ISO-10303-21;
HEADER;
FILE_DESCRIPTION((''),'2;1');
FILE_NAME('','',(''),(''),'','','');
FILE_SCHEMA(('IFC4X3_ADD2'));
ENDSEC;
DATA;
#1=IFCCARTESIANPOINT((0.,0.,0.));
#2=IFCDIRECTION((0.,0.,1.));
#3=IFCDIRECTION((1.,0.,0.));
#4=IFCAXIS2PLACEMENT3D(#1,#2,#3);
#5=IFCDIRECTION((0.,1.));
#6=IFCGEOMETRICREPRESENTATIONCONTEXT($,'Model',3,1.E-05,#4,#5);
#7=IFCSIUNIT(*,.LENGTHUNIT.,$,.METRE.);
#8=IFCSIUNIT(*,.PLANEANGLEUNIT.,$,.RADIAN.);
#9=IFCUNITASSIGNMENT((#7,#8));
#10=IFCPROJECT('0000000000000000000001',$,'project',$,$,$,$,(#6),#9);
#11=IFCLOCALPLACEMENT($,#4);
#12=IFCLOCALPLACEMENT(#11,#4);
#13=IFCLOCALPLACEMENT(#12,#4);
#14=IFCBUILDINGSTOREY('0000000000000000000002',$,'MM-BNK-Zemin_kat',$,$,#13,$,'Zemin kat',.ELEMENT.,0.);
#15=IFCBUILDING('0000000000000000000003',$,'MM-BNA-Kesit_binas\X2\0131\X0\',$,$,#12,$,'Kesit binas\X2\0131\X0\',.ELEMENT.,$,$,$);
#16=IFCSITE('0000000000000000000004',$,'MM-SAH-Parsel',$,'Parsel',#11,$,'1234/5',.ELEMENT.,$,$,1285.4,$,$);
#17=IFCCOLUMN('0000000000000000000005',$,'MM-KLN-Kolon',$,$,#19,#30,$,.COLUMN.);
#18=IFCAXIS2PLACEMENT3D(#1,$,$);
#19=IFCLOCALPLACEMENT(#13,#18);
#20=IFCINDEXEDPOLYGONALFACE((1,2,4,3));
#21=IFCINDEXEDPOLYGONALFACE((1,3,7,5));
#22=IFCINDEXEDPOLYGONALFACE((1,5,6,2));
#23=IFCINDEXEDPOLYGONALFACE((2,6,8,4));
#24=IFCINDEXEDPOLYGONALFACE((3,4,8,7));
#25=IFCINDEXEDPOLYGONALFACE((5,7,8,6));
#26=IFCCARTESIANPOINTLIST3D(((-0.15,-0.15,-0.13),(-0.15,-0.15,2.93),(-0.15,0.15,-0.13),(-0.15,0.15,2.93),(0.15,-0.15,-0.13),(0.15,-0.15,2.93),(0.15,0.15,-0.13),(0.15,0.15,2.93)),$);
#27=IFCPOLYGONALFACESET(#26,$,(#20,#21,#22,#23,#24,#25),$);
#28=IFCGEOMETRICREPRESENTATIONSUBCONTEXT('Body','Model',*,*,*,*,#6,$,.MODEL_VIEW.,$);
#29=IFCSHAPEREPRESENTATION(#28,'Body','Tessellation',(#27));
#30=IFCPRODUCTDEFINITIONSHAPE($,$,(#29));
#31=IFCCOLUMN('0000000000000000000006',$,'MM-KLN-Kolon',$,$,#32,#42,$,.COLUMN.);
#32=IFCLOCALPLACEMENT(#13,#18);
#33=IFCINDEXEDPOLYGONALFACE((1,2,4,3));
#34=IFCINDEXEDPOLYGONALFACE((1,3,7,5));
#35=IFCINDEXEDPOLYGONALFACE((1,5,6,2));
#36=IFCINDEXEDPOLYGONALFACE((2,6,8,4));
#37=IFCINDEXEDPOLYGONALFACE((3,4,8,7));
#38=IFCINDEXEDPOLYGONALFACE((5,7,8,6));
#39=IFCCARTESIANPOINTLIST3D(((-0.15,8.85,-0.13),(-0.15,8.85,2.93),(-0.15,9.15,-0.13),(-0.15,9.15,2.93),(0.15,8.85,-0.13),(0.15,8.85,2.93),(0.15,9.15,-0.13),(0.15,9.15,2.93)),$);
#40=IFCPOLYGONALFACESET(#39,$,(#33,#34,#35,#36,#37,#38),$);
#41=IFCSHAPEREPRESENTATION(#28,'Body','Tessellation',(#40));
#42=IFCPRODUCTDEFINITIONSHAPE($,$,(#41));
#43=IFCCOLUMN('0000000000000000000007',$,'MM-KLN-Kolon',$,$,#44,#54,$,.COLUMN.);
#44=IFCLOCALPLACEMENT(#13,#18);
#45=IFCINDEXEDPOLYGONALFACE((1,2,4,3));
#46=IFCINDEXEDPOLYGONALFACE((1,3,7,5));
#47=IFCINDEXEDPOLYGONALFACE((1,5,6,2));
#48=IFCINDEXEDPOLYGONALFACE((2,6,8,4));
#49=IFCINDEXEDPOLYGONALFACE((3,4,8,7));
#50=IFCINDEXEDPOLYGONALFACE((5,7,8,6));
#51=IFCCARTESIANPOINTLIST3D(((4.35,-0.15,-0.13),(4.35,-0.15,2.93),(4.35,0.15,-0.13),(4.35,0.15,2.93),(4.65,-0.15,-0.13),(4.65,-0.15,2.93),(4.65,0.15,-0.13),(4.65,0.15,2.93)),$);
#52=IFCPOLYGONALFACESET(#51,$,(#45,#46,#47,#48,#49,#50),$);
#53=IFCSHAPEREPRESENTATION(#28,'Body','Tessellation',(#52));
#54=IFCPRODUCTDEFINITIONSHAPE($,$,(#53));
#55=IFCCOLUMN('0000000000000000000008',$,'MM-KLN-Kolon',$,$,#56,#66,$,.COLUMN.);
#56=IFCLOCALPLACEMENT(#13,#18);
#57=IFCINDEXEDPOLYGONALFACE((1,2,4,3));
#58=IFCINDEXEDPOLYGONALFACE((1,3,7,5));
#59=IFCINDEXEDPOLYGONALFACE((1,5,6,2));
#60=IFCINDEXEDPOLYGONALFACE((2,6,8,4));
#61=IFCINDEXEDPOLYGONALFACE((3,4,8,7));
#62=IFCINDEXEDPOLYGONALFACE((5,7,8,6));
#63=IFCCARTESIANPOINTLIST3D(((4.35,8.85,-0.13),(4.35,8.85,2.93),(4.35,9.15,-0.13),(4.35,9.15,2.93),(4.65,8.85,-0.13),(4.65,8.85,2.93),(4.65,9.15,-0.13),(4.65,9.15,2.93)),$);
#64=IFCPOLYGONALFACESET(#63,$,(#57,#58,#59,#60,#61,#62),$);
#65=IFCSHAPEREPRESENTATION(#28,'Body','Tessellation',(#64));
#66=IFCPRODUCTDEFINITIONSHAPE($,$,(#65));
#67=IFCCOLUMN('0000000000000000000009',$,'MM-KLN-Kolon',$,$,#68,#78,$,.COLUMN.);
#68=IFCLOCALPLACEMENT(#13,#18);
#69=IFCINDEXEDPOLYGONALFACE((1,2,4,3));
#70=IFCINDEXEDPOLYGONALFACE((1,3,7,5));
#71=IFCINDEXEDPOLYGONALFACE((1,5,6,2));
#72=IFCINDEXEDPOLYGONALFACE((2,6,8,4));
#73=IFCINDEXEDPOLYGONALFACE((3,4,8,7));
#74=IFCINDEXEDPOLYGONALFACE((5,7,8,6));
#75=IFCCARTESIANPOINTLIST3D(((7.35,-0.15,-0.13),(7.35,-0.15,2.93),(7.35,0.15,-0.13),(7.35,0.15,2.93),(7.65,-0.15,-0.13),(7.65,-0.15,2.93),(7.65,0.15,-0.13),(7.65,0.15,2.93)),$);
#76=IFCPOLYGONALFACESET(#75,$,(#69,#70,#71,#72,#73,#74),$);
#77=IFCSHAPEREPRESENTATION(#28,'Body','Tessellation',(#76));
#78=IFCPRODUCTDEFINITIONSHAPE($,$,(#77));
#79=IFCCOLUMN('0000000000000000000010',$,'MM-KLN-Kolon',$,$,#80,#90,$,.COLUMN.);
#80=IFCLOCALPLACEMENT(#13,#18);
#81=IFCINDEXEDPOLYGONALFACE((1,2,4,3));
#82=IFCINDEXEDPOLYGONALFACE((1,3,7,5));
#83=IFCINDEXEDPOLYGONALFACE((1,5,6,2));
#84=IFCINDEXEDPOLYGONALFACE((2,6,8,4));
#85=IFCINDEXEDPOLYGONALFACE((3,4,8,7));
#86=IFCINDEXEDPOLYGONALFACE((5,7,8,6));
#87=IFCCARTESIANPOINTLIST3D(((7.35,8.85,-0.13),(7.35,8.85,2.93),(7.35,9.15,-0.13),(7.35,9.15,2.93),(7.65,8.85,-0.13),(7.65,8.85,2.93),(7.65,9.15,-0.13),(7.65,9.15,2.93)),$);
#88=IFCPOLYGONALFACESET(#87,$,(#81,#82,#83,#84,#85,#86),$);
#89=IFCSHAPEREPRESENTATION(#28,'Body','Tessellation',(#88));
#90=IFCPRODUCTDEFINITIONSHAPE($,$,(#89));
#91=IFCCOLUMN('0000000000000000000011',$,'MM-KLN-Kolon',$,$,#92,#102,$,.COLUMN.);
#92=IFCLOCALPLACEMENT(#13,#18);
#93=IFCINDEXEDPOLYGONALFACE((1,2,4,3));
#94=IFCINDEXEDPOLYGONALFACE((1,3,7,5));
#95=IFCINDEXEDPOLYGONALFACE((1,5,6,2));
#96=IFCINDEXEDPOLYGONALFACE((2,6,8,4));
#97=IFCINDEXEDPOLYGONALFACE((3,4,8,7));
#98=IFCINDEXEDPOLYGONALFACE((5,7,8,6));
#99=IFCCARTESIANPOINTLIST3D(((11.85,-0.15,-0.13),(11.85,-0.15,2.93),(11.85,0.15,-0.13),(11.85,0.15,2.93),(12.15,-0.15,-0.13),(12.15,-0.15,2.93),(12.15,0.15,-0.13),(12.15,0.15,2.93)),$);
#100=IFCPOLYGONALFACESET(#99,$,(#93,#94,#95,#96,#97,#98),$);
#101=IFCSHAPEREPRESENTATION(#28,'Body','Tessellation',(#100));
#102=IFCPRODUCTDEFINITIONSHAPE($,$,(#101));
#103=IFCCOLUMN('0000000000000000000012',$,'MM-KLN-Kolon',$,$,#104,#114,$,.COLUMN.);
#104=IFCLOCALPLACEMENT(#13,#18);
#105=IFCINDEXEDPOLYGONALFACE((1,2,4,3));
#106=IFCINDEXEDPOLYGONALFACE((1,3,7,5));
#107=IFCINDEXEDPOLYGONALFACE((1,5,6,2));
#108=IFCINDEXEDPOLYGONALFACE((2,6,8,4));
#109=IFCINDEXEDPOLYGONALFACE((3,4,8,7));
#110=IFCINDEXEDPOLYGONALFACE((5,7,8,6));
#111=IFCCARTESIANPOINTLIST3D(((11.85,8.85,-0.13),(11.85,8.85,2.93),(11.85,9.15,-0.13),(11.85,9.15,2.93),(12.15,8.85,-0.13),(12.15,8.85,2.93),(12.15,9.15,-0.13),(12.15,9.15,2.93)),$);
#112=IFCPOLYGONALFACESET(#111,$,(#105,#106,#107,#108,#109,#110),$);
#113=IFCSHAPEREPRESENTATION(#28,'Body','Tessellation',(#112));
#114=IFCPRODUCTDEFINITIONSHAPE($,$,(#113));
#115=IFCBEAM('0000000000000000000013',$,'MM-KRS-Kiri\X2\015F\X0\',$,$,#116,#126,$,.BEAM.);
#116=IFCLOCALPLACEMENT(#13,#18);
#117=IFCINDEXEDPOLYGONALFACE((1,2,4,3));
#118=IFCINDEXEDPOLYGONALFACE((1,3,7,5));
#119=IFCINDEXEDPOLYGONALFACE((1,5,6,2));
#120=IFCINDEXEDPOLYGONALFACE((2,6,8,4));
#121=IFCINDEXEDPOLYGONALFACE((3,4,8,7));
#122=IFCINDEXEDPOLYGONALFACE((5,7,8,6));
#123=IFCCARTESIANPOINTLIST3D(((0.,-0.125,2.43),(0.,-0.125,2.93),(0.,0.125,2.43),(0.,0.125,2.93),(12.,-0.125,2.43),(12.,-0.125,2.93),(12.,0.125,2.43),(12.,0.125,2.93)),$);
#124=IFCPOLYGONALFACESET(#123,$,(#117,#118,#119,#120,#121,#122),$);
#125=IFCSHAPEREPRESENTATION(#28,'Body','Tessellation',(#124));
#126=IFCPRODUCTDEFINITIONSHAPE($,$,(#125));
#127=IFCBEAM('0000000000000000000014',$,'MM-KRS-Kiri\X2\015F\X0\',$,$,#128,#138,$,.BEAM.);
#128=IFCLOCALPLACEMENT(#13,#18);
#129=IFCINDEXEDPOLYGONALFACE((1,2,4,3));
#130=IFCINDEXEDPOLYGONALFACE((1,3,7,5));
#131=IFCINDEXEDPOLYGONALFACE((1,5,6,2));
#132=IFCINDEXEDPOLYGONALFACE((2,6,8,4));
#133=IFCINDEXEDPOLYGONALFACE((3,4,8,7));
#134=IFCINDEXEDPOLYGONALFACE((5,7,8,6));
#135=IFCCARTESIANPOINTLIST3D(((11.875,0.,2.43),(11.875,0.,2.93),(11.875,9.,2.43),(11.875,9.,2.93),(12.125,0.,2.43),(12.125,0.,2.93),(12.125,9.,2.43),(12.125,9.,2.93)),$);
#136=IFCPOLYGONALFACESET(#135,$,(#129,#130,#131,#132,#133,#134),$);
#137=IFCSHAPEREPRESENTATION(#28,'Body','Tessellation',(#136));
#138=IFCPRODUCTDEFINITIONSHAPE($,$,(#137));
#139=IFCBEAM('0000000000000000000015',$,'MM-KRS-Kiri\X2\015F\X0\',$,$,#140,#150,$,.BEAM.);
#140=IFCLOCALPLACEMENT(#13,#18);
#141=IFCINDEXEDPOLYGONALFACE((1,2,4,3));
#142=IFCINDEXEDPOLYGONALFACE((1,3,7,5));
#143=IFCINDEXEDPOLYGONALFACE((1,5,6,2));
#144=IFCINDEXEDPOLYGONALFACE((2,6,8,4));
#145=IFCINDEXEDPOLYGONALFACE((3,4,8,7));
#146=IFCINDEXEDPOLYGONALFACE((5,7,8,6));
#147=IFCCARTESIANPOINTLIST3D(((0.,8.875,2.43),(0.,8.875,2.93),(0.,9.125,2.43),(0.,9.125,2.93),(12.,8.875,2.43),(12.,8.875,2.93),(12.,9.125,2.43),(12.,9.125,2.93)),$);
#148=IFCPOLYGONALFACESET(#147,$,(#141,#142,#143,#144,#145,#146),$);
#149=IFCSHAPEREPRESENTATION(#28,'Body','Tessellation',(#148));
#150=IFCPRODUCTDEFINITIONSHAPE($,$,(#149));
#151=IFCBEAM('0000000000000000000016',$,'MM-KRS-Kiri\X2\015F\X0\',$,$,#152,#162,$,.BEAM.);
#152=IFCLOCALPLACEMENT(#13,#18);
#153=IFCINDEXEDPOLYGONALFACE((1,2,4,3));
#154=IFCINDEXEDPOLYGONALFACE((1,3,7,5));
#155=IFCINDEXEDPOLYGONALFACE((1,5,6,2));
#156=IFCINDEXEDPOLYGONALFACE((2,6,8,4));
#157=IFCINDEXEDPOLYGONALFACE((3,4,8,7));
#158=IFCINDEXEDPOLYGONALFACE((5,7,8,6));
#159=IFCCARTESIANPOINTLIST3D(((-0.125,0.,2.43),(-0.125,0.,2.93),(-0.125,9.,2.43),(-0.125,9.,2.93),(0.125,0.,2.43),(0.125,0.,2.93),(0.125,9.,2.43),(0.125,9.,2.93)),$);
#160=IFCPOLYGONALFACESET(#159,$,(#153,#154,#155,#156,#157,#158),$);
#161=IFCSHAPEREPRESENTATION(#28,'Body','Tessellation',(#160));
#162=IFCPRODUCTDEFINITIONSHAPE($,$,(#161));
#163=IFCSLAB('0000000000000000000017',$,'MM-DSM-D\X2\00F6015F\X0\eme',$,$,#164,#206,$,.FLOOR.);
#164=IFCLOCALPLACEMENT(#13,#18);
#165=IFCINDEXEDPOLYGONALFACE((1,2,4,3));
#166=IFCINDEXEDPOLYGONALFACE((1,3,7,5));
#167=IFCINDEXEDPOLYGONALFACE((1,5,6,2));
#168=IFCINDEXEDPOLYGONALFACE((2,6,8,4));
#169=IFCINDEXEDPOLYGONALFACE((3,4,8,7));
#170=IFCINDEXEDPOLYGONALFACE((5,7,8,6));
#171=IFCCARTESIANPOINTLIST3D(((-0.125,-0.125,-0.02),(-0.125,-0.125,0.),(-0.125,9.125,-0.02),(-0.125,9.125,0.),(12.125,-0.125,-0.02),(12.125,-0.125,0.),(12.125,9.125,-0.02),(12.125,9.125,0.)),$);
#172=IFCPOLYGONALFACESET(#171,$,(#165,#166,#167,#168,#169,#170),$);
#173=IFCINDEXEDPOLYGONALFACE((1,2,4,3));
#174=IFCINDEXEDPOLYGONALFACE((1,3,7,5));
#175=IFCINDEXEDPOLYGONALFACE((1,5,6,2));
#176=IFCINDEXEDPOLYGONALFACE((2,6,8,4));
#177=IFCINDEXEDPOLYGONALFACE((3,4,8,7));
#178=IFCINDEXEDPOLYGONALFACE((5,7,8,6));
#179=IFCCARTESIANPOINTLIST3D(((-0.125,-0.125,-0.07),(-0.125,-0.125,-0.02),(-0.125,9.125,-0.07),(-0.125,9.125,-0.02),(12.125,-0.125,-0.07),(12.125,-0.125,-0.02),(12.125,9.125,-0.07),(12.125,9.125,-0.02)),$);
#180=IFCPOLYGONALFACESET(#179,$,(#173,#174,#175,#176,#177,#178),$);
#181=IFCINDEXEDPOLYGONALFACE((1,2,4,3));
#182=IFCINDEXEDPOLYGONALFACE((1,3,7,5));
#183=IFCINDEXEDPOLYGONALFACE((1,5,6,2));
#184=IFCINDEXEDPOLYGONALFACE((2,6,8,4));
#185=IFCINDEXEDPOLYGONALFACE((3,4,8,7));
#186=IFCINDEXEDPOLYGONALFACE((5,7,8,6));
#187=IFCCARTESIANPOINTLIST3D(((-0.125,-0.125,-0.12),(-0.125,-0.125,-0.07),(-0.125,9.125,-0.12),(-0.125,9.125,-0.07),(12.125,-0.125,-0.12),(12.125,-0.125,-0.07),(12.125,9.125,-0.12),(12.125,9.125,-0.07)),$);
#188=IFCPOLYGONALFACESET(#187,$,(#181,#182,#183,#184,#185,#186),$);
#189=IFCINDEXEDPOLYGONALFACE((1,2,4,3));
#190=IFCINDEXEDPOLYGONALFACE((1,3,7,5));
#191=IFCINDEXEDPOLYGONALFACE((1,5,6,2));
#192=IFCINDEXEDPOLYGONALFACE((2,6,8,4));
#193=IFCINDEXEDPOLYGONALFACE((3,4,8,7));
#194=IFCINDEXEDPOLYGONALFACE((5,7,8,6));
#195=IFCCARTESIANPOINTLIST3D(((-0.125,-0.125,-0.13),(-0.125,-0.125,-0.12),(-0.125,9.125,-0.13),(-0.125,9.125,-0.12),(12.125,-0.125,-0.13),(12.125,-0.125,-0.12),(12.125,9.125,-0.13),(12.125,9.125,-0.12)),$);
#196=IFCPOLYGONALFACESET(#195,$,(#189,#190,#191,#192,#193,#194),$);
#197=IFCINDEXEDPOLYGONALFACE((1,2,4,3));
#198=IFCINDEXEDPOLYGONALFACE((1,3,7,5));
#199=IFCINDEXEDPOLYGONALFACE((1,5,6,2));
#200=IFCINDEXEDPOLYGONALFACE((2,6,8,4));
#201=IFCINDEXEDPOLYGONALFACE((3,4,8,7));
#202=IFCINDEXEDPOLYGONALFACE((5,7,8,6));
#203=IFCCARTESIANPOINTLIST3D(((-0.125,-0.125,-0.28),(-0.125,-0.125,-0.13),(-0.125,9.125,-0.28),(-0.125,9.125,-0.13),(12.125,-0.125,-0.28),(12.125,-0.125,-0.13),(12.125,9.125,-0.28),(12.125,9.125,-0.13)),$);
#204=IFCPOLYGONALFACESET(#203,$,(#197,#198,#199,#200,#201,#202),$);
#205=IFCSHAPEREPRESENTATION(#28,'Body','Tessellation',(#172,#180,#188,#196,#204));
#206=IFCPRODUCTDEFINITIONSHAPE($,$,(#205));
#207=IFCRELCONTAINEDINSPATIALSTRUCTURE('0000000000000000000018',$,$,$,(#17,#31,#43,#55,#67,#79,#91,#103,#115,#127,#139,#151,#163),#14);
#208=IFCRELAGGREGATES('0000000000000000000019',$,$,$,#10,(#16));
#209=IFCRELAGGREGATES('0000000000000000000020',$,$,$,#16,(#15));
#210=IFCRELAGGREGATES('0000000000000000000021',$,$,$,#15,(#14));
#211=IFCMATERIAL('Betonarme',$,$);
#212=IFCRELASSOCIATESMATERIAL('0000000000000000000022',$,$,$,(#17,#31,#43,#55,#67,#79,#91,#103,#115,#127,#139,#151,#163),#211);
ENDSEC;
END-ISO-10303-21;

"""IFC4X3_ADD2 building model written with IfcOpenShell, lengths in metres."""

from ifc_helpers import new_model, si_unit, direction, frame, origin_with_axes, place, context, subcontext, project, spatial, polyline, outline, extrude, material, element, save


model = new_model("IFC4X3_ADD2")

# Units and contexts
model_context = context("Model", 3, precision=1e-05, world=origin_with_axes(), true_north=direction((0.0, 1.0)))
body_context = subcontext(model_context, "Body", "Model", "MODEL_VIEW")
ifc_project = project(units=[si_unit("LENGTHUNIT", "METRE"), si_unit("PLANEANGLEUNIT", "RADIAN")], contexts=[model_context])

# Site, building, storey
site_placement = place(None, origin_with_axes())
site = spatial("IfcSite", under=ifc_project, at=site_placement, Name="MM-SAH-Parsel", ObjectType="Parsel", LongName="1234/5", CompositionType="ELEMENT", RefElevation=1285.4)
building_placement = place(site_placement, origin_with_axes())
building = spatial("IfcBuilding", under=site, at=building_placement, Name="MM-BNA-Kesit_binası", LongName="Kesit binası", CompositionType="ELEMENT")
storey_placement = place(building_placement, origin_with_axes())
storey = spatial("IfcBuildingStorey", under=building, at=storey_placement, Name="MM-BNK-Zemin_kat", LongName="Zemin kat", CompositionType="ELEMENT", Elevation=0.0)

# Columns
ifc_material_1 = material(Name="Betonarme")
column_1_placement = place(storey_placement, origin_with_axes())
element("IfcColumn", 1, at=column_1_placement, inside=storey, material=ifc_material_1, Name="MM-KLN-Kolon", PredefinedType="COLUMN", context=body_context, shape_type="SweptSolid", body=[
    extrude(outline(polyline([(-0.15, -0.15), (0.15, -0.15), (0.15, 0.15), (-0.15, 0.15), (-0.15, -0.15)])), frame((0.0, 0.0, -0.13)), (0.0, 0.0, 1.0), 3.06),
])
column_2_placement = place(storey_placement, origin_with_axes())
element("IfcColumn", 2, at=column_2_placement, inside=storey, material=ifc_material_1, Name="MM-KLN-Kolon", PredefinedType="COLUMN", context=body_context, shape_type="SweptSolid", body=[
    extrude(outline(polyline([(-0.15, 8.85), (0.15, 8.85), (0.15, 9.15), (-0.15, 9.15), (-0.15, 8.85)])), frame((0.0, 0.0, -0.13)), (0.0, 0.0, 1.0), 3.06),
])
column_3_placement = place(storey_placement, origin_with_axes())
element("IfcColumn", 3, at=column_3_placement, inside=storey, material=ifc_material_1, Name="MM-KLN-Kolon", PredefinedType="COLUMN", context=body_context, shape_type="SweptSolid", body=[
    extrude(outline(polyline([(4.35, -0.15), (4.65, -0.15), (4.65, 0.15), (4.35, 0.15), (4.35, -0.15)])), frame((0.0, 0.0, -0.13)), (0.0, 0.0, 1.0), 3.06),
])
column_4_placement = place(storey_placement, origin_with_axes())
element("IfcColumn", 4, at=column_4_placement, inside=storey, material=ifc_material_1, Name="MM-KLN-Kolon", PredefinedType="COLUMN", context=body_context, shape_type="SweptSolid", body=[
    extrude(outline(polyline([(4.35, 8.85), (4.65, 8.85), (4.65, 9.15), (4.35, 9.15), (4.35, 8.85)])), frame((0.0, 0.0, -0.13)), (0.0, 0.0, 1.0), 3.06),
])
column_5_placement = place(storey_placement, origin_with_axes())
element("IfcColumn", 5, at=column_5_placement, inside=storey, material=ifc_material_1, Name="MM-KLN-Kolon", PredefinedType="COLUMN", context=body_context, shape_type="SweptSolid", body=[
    extrude(outline(polyline([(7.35, -0.15), (7.65, -0.15), (7.65, 0.15), (7.35, 0.15), (7.35, -0.15)])), frame((0.0, 0.0, -0.13)), (0.0, 0.0, 1.0), 3.06),
])
column_6_placement = place(storey_placement, origin_with_axes())
element("IfcColumn", 6, at=column_6_placement, inside=storey, material=ifc_material_1, Name="MM-KLN-Kolon", PredefinedType="COLUMN", context=body_context, shape_type="SweptSolid", body=[
    extrude(outline(polyline([(7.35, 8.85), (7.65, 8.85), (7.65, 9.15), (7.35, 9.15), (7.35, 8.85)])), frame((0.0, 0.0, -0.13)), (0.0, 0.0, 1.0), 3.06),
])
column_7_placement = place(storey_placement, origin_with_axes())
element("IfcColumn", 7, at=column_7_placement, inside=storey, material=ifc_material_1, Name="MM-KLN-Kolon", PredefinedType="COLUMN", context=body_context, shape_type="SweptSolid", body=[
    extrude(outline(polyline([(11.85, -0.15), (12.15, -0.15), (12.15, 0.15), (11.85, 0.15), (11.85, -0.15)])), frame((0.0, 0.0, -0.13)), (0.0, 0.0, 1.0), 3.06),
])
column_8_placement = place(storey_placement, origin_with_axes())
element("IfcColumn", 8, at=column_8_placement, inside=storey, material=ifc_material_1, Name="MM-KLN-Kolon", PredefinedType="COLUMN", context=body_context, shape_type="SweptSolid", body=[
    extrude(outline(polyline([(11.85, 8.85), (12.15, 8.85), (12.15, 9.15), (11.85, 9.15), (11.85, 8.85)])), frame((0.0, 0.0, -0.13)), (0.0, 0.0, 1.0), 3.06),
])

# Beams
beam_1_placement = place(storey_placement, origin_with_axes())
element("IfcBeam", 9, at=beam_1_placement, inside=storey, material=ifc_material_1, Name="MM-KRS-Kiriş", PredefinedType="BEAM", context=body_context, shape_type="SweptSolid", body=[
    extrude(outline(polyline([(0.0, 0.125), (12.0, 0.125), (12.0, -0.125), (0.0, -0.125), (0.0, 0.125)])), frame((0.0, 0.0, 2.43)), (0.0, 0.0, 1.0), 0.5),
])
beam_2_placement = place(storey_placement, origin_with_axes())
element("IfcBeam", 10, at=beam_2_placement, inside=storey, material=ifc_material_1, Name="MM-KRS-Kiriş", PredefinedType="BEAM", context=body_context, shape_type="SweptSolid", body=[
    extrude(outline(polyline([(11.875, 0.0), (11.875, 9.0), (12.125, 9.0), (12.125, 0.0), (11.875, 0.0)])), frame((0.0, 0.0, 2.43)), (0.0, 0.0, 1.0), 0.5),
])
beam_3_placement = place(storey_placement, origin_with_axes())
element("IfcBeam", 11, at=beam_3_placement, inside=storey, material=ifc_material_1, Name="MM-KRS-Kiriş", PredefinedType="BEAM", context=body_context, shape_type="SweptSolid", body=[
    extrude(outline(polyline([(12.0, 8.875), (0.0, 8.875), (0.0, 9.125), (12.0, 9.125), (12.0, 8.875)])), frame((0.0, 0.0, 2.43)), (0.0, 0.0, 1.0), 0.5),
])
beam_4_placement = place(storey_placement, origin_with_axes())
element("IfcBeam", 12, at=beam_4_placement, inside=storey, material=ifc_material_1, Name="MM-KRS-Kiriş", PredefinedType="BEAM", context=body_context, shape_type="SweptSolid", body=[
    extrude(outline(polyline([(0.125, 9.0), (0.125, 0.0), (-0.125, 0.0), (-0.125, 9.0), (0.125, 9.0)])), frame((0.0, 0.0, 2.43)), (0.0, 0.0, 1.0), 0.5),
])

# Slab
slab_placement = place(storey_placement, origin_with_axes())
element("IfcSlab", 13, at=slab_placement, inside=storey, material=ifc_material_1, Name="MM-DSM-Döşeme", PredefinedType="FLOOR", context=body_context, shape_type="SweptSolid", body=[
    extrude(outline(polyline([(-0.125, -0.125), (12.125, -0.125), (12.125, 9.125), (-0.125, 9.125), (-0.125, -0.125)])), frame((0.0, 0.0, -0.02)), (0.0, 0.0, 1.0), 0.02),
    extrude(outline(polyline([(-0.125, -0.125), (12.125, -0.125), (12.125, 9.125), (-0.125, 9.125), (-0.125, -0.125)])), frame((0.0, 0.0, -0.07)), (0.0, 0.0, 1.0), 0.05),
    extrude(outline(polyline([(-0.125, -0.125), (12.125, -0.125), (12.125, 9.125), (-0.125, 9.125), (-0.125, -0.125)])), frame((0.0, 0.0, -0.12)), (0.0, 0.0, 1.0), 0.05),
    extrude(outline(polyline([(-0.125, -0.125), (12.125, -0.125), (12.125, 9.125), (-0.125, 9.125), (-0.125, -0.125)])), frame((0.0, 0.0, -0.13)), (0.0, 0.0, 1.0), 0.01),
    extrude(outline(polyline([(-0.125, -0.125), (12.125, -0.125), (12.125, 9.125), (-0.125, 9.125), (-0.125, -0.125)])), frame((0.0, 0.0, -0.28)), (0.0, 0.0, 1.0), 0.15),
])

save(model, "model.ifc")
